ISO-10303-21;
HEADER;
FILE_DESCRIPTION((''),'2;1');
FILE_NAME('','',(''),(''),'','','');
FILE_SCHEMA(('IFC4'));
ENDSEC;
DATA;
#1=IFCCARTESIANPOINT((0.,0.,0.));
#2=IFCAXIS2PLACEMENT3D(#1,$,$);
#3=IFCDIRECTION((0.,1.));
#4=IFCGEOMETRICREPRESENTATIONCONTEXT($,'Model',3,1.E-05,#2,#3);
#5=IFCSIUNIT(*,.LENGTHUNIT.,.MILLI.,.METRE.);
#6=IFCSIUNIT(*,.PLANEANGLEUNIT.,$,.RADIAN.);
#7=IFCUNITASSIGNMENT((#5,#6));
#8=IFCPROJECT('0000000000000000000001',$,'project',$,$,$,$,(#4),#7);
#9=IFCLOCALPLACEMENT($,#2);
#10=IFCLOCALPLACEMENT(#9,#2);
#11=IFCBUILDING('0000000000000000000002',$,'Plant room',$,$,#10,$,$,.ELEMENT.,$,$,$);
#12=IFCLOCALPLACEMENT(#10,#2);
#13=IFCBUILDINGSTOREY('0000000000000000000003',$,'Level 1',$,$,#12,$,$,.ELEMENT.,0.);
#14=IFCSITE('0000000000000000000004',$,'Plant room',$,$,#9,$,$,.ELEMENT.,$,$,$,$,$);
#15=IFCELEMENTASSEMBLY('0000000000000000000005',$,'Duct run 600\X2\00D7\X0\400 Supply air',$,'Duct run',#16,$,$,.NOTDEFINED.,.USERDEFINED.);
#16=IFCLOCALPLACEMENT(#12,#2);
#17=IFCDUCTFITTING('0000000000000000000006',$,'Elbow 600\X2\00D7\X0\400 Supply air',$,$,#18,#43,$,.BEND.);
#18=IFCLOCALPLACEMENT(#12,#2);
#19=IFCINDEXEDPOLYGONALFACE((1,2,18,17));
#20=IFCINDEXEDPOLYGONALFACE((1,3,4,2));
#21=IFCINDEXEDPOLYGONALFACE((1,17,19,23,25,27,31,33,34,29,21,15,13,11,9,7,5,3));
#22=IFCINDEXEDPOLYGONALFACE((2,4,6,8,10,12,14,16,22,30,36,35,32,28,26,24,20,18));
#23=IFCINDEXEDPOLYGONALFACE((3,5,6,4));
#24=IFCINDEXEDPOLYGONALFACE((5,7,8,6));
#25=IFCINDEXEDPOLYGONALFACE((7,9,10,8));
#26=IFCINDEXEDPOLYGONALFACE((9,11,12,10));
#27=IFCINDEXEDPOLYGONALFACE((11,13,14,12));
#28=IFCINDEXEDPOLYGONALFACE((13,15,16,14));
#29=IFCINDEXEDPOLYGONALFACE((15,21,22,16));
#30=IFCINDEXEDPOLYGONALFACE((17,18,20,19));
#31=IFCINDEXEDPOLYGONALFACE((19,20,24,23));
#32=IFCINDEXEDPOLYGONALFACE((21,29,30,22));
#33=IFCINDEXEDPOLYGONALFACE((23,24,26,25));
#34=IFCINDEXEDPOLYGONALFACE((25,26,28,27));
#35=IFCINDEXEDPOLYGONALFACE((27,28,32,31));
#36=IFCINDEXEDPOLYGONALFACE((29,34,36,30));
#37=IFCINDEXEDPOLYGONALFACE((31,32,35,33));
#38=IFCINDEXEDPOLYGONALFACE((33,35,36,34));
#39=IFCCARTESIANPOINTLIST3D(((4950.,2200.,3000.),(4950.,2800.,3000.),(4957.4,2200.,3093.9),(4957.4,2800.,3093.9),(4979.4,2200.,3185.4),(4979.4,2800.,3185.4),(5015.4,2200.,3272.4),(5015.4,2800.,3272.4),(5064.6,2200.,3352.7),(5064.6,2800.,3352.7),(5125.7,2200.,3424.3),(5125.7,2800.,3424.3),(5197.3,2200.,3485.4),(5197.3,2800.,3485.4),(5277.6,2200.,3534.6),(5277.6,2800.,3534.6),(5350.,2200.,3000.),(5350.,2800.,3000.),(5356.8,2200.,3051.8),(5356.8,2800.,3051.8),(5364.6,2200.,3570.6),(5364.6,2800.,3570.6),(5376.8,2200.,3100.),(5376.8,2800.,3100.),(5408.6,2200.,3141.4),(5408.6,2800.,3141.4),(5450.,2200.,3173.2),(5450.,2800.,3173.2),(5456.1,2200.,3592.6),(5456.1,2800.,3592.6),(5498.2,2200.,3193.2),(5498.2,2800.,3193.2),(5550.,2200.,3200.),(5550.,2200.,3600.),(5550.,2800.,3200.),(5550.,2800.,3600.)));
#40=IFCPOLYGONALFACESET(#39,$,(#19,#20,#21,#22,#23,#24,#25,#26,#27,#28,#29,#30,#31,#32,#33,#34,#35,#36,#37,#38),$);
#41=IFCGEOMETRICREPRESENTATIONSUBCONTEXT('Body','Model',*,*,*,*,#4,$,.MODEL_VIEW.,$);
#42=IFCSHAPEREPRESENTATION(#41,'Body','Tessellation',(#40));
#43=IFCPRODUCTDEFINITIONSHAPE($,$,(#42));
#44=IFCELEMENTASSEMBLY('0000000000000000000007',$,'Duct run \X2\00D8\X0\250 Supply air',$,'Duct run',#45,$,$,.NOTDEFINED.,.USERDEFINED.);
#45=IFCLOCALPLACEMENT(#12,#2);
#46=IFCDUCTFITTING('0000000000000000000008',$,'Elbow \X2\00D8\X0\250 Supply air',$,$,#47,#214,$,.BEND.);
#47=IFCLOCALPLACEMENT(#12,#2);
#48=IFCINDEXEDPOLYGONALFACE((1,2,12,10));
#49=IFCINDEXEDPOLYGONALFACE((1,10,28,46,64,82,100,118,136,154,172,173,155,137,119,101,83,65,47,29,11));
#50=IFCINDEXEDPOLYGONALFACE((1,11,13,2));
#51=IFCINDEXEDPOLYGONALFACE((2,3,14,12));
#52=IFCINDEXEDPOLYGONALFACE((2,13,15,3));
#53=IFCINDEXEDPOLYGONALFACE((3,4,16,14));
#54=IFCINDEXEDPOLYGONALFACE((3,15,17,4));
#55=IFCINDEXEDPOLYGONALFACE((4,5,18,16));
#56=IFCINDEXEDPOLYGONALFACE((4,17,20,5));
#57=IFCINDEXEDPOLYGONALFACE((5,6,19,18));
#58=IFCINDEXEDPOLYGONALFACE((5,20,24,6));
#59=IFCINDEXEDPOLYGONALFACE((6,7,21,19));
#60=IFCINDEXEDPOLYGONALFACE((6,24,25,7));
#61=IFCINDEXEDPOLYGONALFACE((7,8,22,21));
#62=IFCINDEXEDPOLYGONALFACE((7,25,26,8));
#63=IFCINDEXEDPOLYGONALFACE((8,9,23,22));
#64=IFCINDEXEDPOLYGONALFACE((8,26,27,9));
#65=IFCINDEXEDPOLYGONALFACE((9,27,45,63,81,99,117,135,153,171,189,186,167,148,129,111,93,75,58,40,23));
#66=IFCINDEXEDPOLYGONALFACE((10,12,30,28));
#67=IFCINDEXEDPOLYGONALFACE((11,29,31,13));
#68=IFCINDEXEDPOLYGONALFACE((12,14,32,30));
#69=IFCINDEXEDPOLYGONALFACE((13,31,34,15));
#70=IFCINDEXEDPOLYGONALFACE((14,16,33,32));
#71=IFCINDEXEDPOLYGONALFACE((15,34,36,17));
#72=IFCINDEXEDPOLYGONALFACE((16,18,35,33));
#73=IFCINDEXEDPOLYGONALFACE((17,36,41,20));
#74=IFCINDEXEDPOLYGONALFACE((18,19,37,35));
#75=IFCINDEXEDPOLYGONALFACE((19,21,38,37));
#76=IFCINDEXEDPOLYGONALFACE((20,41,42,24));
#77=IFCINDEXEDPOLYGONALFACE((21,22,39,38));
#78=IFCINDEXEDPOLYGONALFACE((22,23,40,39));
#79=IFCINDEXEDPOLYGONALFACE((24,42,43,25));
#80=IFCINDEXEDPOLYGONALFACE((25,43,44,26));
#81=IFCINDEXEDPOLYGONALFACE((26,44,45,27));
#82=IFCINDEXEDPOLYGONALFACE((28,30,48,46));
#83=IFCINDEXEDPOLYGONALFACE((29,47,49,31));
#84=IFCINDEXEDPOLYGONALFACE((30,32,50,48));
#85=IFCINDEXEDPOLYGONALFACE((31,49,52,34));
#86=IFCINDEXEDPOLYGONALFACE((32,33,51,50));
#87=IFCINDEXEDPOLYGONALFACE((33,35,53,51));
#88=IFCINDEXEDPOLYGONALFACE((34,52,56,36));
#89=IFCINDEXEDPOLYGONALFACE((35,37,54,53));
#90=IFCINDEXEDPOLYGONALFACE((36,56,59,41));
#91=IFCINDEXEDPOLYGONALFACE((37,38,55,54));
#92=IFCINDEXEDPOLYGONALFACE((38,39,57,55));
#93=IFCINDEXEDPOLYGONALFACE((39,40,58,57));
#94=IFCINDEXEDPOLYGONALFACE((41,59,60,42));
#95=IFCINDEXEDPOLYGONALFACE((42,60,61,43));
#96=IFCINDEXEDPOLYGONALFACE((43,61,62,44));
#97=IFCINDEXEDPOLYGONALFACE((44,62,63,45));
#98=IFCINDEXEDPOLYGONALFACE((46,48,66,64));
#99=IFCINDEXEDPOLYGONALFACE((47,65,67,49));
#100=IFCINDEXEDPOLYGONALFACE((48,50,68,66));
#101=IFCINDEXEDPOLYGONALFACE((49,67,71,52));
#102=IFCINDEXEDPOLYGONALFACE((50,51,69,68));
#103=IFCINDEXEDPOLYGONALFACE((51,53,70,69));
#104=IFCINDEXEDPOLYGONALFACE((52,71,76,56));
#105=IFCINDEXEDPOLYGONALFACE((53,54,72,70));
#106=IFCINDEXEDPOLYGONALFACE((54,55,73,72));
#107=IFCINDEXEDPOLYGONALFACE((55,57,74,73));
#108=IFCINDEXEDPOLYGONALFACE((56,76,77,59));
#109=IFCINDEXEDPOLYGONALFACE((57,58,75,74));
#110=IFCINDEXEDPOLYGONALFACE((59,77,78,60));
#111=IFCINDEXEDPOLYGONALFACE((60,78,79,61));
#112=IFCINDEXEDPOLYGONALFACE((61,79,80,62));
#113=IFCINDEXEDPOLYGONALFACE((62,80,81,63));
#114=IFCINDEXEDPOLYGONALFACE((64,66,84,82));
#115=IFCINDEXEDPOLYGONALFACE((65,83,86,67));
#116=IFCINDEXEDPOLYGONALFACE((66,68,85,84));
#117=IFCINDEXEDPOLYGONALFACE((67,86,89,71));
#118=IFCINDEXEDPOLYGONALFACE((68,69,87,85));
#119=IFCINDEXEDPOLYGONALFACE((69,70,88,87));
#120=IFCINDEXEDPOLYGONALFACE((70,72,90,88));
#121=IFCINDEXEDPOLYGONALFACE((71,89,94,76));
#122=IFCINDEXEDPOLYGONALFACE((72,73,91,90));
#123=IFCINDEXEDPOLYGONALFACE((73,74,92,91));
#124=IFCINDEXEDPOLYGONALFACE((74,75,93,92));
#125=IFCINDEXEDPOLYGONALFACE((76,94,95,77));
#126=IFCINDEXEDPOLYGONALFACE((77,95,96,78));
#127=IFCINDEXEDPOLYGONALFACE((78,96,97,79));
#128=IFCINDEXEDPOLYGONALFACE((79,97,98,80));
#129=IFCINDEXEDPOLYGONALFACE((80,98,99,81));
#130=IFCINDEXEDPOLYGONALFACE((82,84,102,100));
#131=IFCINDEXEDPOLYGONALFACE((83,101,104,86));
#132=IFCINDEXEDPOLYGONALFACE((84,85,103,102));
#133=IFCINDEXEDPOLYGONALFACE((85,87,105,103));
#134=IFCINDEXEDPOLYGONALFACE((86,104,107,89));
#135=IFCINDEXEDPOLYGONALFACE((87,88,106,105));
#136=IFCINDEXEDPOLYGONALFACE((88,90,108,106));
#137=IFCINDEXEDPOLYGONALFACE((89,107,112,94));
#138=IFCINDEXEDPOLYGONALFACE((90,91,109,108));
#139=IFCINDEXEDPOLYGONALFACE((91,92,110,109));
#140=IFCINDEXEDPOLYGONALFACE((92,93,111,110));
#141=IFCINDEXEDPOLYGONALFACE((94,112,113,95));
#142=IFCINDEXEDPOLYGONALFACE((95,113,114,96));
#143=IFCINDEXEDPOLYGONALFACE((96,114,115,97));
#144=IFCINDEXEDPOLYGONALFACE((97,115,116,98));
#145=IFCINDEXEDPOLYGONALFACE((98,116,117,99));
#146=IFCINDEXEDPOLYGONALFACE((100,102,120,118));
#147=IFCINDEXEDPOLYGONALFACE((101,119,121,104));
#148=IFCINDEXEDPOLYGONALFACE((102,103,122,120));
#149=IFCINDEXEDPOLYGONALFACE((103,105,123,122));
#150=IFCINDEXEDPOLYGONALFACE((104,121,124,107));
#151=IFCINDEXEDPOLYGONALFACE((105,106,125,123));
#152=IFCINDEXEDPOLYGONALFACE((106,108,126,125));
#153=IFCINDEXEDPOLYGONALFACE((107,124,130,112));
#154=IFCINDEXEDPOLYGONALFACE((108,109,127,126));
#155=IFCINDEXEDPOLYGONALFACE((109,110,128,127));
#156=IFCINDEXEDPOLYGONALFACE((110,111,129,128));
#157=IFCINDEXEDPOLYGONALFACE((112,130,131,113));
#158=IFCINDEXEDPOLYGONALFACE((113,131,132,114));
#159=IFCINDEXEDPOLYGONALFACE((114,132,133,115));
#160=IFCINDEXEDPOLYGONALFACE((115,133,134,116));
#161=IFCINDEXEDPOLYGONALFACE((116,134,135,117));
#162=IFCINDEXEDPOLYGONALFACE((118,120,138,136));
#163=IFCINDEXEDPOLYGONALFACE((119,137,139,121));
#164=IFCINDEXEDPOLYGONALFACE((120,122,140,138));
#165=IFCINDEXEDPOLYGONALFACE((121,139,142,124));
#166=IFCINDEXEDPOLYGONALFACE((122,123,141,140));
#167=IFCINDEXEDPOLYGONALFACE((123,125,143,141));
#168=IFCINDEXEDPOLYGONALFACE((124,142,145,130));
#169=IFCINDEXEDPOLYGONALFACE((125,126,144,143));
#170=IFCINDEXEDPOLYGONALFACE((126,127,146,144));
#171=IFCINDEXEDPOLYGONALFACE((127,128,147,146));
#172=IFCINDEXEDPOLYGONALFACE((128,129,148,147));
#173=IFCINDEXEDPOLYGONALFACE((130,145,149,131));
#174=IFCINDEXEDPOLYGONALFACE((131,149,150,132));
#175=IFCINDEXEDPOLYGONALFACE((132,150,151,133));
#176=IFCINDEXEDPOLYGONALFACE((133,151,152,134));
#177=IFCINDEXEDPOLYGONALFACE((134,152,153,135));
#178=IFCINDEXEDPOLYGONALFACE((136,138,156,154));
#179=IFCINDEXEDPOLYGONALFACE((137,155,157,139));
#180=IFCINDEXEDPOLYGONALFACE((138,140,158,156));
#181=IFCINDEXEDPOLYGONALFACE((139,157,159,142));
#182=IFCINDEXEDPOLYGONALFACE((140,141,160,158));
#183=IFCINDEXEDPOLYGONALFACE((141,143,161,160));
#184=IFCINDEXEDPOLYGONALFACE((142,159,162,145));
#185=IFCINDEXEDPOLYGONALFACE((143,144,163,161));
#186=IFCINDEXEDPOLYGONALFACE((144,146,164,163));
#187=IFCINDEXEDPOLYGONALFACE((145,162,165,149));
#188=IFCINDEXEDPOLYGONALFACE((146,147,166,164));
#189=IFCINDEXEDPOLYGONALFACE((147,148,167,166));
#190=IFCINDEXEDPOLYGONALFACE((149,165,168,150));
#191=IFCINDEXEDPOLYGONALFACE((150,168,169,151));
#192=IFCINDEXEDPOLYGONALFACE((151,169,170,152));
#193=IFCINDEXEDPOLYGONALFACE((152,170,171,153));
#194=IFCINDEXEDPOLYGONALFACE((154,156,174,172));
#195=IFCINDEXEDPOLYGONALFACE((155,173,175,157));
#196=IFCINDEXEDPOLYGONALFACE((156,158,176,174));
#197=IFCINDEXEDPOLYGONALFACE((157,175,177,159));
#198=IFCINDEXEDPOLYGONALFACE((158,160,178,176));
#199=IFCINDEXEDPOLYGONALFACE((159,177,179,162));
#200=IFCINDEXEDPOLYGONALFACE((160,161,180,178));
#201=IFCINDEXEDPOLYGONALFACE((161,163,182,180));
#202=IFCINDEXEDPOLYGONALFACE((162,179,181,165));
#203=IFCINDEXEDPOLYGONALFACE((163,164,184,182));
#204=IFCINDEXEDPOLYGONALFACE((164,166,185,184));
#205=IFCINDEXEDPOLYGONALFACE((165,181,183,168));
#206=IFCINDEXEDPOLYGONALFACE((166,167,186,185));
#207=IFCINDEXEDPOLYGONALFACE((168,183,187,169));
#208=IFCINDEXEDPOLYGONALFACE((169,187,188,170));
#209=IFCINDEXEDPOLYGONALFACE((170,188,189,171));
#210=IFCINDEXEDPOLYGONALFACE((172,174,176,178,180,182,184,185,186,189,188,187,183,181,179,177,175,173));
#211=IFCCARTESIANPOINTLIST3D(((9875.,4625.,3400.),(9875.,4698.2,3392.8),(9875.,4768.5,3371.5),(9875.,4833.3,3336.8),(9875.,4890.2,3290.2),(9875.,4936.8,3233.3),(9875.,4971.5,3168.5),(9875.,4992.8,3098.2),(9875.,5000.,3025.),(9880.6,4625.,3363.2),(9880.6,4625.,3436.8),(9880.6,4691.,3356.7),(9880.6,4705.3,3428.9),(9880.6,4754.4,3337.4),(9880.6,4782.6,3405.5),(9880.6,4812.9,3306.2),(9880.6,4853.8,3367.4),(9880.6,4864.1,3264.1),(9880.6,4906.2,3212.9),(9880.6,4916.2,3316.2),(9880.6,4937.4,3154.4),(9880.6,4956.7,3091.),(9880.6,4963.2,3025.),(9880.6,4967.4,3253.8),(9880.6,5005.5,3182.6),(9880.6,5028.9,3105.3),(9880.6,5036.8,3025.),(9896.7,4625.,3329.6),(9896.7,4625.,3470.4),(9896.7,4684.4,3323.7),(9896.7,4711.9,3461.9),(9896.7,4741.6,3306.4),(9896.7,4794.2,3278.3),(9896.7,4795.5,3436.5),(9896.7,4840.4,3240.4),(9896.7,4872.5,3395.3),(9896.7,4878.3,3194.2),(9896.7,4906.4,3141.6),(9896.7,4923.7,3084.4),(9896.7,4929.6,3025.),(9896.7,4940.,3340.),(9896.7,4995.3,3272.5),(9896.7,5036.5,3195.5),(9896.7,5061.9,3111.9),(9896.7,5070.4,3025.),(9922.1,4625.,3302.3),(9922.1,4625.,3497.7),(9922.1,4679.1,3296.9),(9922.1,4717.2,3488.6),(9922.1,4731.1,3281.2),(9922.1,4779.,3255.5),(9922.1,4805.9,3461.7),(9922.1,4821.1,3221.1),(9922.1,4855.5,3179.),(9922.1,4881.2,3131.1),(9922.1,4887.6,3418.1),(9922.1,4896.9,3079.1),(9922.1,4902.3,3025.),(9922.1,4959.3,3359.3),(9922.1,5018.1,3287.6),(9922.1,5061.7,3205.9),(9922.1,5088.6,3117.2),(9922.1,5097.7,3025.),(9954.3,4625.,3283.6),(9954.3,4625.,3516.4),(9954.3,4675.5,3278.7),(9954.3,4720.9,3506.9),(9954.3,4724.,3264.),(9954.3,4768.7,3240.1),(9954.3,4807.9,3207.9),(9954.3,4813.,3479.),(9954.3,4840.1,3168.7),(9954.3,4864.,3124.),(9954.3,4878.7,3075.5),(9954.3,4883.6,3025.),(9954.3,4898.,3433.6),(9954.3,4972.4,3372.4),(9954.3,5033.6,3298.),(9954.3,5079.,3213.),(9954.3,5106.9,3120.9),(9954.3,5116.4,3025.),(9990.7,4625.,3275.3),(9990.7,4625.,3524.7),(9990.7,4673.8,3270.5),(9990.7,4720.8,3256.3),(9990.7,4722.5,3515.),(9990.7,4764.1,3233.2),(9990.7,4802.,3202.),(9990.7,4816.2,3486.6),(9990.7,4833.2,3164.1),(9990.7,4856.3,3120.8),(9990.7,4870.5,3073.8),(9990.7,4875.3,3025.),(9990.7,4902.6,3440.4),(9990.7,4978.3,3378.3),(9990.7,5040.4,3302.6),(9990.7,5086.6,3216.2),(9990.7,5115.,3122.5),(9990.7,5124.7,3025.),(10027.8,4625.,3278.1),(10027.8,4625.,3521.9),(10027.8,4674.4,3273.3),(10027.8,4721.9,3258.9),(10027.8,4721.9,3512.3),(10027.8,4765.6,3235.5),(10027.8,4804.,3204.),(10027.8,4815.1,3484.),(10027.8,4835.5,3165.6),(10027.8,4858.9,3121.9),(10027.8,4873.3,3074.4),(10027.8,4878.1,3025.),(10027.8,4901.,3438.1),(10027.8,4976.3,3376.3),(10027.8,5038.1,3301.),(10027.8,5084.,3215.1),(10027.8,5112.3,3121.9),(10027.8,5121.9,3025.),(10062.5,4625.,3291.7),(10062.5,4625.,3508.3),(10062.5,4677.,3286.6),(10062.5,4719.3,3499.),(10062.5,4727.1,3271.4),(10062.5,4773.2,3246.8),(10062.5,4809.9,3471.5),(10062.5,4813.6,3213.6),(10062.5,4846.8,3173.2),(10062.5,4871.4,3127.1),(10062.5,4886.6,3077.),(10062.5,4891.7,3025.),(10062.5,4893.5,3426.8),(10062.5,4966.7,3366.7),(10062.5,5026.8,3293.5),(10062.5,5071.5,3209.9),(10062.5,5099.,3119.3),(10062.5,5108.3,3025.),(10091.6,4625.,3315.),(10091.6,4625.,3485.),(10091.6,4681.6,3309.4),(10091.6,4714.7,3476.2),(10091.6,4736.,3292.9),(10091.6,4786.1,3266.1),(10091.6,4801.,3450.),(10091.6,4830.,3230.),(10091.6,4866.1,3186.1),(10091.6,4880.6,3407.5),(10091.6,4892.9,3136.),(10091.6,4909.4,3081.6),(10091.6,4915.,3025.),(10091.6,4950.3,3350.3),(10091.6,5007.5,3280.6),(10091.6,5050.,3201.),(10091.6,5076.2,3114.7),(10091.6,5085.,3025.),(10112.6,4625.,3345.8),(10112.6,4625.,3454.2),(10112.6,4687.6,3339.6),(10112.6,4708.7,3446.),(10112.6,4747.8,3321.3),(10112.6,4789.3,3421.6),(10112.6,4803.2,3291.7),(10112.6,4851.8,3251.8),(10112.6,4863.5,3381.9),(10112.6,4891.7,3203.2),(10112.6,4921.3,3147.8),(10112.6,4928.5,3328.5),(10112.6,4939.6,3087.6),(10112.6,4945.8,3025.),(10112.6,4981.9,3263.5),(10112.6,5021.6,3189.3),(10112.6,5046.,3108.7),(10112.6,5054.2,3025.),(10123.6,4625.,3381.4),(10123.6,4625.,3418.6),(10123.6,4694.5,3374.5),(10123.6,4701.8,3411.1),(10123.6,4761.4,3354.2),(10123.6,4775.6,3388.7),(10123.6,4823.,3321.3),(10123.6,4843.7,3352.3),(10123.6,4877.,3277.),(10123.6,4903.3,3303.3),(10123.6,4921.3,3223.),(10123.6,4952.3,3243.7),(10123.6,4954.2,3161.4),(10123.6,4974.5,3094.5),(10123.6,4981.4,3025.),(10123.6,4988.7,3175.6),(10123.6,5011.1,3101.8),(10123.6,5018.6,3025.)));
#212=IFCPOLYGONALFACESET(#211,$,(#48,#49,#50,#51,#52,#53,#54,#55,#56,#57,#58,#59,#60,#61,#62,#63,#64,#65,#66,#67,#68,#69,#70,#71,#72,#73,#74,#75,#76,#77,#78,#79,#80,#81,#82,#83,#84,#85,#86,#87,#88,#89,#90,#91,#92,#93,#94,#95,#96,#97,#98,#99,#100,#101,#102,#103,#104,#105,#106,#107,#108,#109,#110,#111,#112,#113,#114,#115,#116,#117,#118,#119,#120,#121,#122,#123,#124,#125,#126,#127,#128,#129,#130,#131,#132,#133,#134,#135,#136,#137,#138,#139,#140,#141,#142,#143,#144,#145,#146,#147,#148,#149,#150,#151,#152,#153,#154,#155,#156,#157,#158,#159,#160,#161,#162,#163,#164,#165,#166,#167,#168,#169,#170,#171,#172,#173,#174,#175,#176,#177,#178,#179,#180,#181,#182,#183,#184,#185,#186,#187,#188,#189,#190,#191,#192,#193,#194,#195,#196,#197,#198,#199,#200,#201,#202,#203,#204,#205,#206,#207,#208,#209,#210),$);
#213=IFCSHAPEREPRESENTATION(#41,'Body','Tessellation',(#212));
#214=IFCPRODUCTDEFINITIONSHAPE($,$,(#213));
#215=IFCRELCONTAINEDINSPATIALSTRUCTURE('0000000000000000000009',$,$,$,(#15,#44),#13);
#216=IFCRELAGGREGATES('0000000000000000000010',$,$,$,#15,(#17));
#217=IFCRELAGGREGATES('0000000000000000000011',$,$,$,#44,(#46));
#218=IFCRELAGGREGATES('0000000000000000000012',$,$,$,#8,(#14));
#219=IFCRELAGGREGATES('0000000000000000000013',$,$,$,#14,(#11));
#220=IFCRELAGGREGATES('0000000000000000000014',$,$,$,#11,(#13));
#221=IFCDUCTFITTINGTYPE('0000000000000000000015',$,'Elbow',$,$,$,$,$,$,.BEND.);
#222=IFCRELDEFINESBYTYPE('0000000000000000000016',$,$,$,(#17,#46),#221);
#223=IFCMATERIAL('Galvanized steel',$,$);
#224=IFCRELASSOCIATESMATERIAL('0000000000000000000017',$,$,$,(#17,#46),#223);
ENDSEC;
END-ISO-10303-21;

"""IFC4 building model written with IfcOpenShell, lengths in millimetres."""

from ifc_helpers import new_model, entity, si_unit, direction, origin, origin_with_axes, place, context, subcontext, project, spatial, material, type_object, element, aggregate, save


model = new_model("IFC4")

# Units and contexts
model_context = context("Model", 3, precision=1e-05, world=origin(), true_north=direction((0.0, 1.0)))
body_context = subcontext(model_context, "Body", "Model", "MODEL_VIEW")
ifc_project = project(units=[si_unit("LENGTHUNIT", "METRE", prefix="MILLI"), si_unit("PLANEANGLEUNIT", "RADIAN")], contexts=[model_context])

# Site, building, storey
site_placement = place(None, origin())
site = spatial("IfcSite", under=ifc_project, at=site_placement, Name="Plant room", CompositionType="ELEMENT")
building_placement = place(site_placement, origin())
building = spatial("IfcBuilding", under=site, at=building_placement, Name="Plant room", CompositionType="ELEMENT")
storey_placement = place(building_placement, origin())
storey = spatial("IfcBuildingStorey", under=building, at=storey_placement, Name="Level 1", CompositionType="ELEMENT", Elevation=0.0)

# Element assembly
assembly_1_placement = place(storey_placement, origin_with_axes())
assembly_1 = element("IfcElementAssembly", 1, at=assembly_1_placement, inside=storey, Name="Duct run 600×400 Supply air", ObjectType="Duct run", AssemblyPlace="NOTDEFINED", PredefinedType="USERDEFINED")
ifc_material_1 = material(Name="Galvanized steel")

# Shared definitions
duct_fitting_type_1 = type_object("IfcDuctFittingType", Name="Elbow", PredefinedType="BEND")

# Duct fitting
duct_fitting_1_placement = place(storey_placement, origin_with_axes())
duct_fitting_1 = element("IfcDuctFitting", 2, at=duct_fitting_1_placement, type_object=duct_fitting_type_1, material=ifc_material_1, Name="Elbow 600×400 Supply air", PredefinedType="BEND", context=body_context, shape_type="SweptSolid", body=[
    entity("IfcRevolvedAreaSolid", entity("IfcRectangleProfileDef", "AREA", None, entity("IfcAxis2Placement2D", entity("IfcCartesianPoint", [0.0, 0.0])), 600.0, 400.0), entity("IfcAxis2Placement3D", entity("IfcCartesianPoint", [5150.0, 2500.0, 3000.0]), entity("IfcDirection", [0.0, 0.0, 1.0]), entity("IfcDirection", [0.0, 1.0, 0.0])), entity("IfcAxis1Placement", entity("IfcCartesianPoint", [0.0, -400.0, 0.0]), entity("IfcDirection", [1.0, 0.0, 0.0])), 1.570796),
])

# Element assembly, duct fitting
assembly_2_placement = place(storey_placement, origin_with_axes())
assembly_2 = element("IfcElementAssembly", 3, at=assembly_2_placement, inside=storey, Name="Duct run Ø250 Supply air", ObjectType="Duct run", AssemblyPlace="NOTDEFINED", PredefinedType="USERDEFINED")
duct_fitting_2_placement = place(storey_placement, origin_with_axes())
duct_fitting_2 = element("IfcDuctFitting", 4, at=duct_fitting_2_placement, type_object=duct_fitting_type_1, material=ifc_material_1, Name="Elbow Ø250 Supply air", PredefinedType="BEND", context=body_context, shape_type="SweptSolid", body=[
    entity("IfcRevolvedAreaSolid", entity("IfcCircleProfileDef", "AREA", None, entity("IfcAxis2Placement2D", entity("IfcCartesianPoint", [0.0, 0.0])), 125.0), entity("IfcAxis2Placement3D", entity("IfcCartesianPoint", [10000.0, 4625.0, 3400.0]), entity("IfcDirection", [0.0, 1.0, 0.0]), entity("IfcDirection", [-1.0, 0.0, 0.0])), entity("IfcAxis1Placement", entity("IfcCartesianPoint", [0.0, -375.0, 0.0]), entity("IfcDirection", [1.0, 0.0, 0.0])), 1.570796),
])

aggregate(assembly_1, [duct_fitting_1])

aggregate(assembly_2, [duct_fitting_2])

save(model, "model.ifc")
